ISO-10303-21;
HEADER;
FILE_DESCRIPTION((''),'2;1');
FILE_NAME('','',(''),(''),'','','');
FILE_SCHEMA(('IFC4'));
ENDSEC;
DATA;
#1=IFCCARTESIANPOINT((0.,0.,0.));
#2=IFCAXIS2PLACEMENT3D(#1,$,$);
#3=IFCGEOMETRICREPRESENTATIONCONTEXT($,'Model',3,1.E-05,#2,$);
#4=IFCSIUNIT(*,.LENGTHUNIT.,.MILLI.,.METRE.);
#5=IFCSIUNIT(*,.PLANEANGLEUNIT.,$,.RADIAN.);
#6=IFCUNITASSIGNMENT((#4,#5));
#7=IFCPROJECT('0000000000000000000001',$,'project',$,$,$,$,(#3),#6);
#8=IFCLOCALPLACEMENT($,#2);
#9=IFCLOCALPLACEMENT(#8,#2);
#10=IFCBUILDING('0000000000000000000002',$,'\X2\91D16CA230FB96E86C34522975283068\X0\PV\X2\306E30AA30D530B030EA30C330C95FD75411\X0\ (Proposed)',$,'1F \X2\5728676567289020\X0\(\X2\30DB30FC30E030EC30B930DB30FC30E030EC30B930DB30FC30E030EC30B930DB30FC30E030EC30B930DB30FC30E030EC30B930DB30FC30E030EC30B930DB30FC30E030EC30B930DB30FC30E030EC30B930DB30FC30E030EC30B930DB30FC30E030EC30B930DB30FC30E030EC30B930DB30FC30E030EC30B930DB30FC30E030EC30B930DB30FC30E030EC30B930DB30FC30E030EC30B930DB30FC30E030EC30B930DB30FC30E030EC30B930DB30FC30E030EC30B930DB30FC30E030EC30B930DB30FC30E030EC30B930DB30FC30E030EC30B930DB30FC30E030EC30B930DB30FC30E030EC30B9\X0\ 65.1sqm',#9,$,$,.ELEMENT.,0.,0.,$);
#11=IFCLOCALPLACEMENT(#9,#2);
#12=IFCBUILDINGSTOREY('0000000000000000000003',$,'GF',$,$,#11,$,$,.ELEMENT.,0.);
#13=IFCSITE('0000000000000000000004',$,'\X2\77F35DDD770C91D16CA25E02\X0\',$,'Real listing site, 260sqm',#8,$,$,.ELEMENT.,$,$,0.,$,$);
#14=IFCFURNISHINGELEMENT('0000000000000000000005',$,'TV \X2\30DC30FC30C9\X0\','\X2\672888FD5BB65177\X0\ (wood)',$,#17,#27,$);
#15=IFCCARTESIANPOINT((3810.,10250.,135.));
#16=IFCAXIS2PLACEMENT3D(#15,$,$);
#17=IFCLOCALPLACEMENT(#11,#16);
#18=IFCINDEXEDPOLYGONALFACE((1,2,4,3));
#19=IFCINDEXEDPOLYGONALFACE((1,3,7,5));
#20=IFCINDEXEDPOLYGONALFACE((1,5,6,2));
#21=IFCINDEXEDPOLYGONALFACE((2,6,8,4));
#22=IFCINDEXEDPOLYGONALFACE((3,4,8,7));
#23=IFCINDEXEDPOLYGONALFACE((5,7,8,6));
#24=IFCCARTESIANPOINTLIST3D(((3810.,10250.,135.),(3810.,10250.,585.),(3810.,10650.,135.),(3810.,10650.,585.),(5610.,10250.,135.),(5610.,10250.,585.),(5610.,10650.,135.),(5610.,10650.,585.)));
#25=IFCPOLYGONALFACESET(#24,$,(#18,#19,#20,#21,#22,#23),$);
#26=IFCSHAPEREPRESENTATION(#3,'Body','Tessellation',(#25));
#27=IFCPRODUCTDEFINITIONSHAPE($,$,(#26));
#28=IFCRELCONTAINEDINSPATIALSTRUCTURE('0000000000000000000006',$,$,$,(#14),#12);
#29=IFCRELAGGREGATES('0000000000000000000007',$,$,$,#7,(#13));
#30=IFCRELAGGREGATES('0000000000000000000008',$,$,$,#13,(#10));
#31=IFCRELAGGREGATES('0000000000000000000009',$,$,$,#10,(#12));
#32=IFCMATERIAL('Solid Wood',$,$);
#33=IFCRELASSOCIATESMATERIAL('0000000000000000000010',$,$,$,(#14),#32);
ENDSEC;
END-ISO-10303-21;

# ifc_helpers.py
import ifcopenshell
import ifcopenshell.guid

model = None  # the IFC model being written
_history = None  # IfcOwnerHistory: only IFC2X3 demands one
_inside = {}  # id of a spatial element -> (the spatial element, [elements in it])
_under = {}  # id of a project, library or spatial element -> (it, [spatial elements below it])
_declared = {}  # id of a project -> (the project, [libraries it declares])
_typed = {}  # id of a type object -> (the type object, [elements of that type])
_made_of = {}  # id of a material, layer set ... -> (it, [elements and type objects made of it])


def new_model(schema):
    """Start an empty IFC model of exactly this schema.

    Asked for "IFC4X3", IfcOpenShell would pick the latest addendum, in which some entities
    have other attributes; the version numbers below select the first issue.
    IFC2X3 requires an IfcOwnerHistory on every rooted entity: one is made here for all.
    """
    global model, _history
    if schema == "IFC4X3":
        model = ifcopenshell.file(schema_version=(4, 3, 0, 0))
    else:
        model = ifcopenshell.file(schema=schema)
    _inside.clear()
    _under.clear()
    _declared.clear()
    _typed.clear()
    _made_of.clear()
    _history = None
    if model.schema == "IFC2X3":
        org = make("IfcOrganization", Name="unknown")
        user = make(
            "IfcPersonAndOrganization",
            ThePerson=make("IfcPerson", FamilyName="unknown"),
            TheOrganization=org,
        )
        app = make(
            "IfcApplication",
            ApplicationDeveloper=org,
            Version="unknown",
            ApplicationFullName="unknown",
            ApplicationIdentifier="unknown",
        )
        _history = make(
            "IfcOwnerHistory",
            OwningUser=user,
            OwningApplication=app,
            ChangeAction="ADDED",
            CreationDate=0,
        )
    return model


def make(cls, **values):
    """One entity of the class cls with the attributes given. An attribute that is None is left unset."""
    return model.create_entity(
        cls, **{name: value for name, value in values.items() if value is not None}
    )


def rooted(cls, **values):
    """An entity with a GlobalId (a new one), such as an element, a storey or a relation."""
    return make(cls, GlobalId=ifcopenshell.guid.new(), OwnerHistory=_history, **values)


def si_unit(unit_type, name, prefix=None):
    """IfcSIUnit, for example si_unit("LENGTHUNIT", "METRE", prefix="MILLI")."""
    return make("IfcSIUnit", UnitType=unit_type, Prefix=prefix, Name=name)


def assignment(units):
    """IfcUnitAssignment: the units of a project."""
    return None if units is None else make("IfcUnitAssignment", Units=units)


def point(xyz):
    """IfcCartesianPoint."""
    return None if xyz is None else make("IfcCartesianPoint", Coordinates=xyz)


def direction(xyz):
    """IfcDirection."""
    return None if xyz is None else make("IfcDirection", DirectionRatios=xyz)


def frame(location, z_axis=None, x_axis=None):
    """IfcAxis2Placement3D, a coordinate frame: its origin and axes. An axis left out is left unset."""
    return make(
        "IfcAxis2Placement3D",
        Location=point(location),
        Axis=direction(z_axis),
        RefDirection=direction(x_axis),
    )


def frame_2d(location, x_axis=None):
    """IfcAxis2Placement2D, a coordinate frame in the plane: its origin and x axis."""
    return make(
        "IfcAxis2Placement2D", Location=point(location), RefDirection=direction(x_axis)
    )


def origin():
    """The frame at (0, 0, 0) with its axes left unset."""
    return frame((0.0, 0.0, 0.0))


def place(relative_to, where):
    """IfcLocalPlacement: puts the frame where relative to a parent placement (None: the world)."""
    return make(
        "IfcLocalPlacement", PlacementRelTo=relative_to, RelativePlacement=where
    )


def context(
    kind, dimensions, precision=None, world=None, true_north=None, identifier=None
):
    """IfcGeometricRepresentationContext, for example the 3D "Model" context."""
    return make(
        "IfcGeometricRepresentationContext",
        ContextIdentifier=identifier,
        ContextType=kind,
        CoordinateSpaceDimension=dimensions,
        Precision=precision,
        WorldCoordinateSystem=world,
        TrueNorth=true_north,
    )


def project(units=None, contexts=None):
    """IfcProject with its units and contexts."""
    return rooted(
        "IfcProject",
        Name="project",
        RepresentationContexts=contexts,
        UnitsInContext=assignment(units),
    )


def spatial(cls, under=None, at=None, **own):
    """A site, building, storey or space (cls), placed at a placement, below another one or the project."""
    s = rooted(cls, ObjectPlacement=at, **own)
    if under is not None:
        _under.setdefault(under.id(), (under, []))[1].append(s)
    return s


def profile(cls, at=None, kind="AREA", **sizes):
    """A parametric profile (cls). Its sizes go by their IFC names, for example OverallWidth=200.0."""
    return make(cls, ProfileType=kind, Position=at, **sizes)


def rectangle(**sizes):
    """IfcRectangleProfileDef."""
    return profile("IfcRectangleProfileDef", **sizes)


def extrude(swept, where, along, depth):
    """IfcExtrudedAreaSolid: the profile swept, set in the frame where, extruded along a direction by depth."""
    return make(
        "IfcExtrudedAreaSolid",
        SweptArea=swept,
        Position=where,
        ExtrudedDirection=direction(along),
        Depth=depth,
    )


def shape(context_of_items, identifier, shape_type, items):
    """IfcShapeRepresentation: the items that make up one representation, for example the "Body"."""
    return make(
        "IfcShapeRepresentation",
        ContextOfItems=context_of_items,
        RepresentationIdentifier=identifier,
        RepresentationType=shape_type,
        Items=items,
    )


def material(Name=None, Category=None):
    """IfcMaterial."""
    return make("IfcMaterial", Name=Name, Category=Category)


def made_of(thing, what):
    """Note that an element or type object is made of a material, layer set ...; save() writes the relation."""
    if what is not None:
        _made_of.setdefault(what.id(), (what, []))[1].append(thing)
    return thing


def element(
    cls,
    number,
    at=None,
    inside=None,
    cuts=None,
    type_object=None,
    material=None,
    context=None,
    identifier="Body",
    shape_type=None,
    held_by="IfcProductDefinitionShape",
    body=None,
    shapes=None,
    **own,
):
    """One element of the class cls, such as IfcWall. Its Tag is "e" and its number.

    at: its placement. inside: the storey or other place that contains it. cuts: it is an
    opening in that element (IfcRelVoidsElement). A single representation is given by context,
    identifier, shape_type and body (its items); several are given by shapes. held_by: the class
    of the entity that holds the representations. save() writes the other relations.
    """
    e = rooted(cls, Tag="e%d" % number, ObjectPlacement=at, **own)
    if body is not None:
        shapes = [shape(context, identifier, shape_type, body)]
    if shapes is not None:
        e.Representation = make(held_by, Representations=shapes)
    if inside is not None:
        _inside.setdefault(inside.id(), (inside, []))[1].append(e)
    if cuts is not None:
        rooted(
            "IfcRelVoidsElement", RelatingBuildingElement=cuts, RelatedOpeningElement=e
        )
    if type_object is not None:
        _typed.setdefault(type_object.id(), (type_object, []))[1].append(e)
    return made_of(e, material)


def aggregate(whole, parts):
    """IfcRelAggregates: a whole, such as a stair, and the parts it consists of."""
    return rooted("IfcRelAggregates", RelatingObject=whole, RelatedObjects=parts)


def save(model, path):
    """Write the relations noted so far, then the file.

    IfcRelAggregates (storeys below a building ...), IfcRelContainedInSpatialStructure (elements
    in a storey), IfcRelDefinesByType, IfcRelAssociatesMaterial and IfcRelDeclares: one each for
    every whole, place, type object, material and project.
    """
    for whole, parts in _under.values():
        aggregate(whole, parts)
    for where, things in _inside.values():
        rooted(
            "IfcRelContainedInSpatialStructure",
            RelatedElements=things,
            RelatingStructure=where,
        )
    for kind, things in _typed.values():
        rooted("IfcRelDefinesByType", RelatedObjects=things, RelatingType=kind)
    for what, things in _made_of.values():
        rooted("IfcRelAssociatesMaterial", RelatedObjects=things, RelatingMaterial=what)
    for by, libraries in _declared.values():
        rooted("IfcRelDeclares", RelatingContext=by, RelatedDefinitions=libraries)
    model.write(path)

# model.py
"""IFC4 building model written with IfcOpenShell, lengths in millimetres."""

from ifc_helpers import new_model, si_unit, frame, frame_2d, origin, place, context, project, spatial, rectangle, extrude, material, element, save


model = new_model("IFC4")

# Units and contexts
model_context = context("Model", 3, precision=1e-05, world=origin())
ifc_project = project(units=[si_unit("LENGTHUNIT", "METRE", prefix="MILLI"), si_unit("PLANEANGLEUNIT", "RADIAN")], contexts=[model_context])

# Site, building, storey
site_placement = place(None, origin())
site = spatial("IfcSite", under=ifc_project, at=site_placement, Name="石川県金沢市", ObjectType="Real listing site, 260sqm", CompositionType="ELEMENT", RefElevation=0.0)
building_placement = place(site_placement, origin())
building = spatial("IfcBuilding", under=site, at=building_placement, Name="金沢・雨水利用とPVのオフグリッド志向 (Proposed)", ObjectType="1F 在来木造(ホームレスホームレスホームレスホームレスホームレスホームレスホームレスホームレスホームレスホームレスホームレスホームレスホームレスホームレスホームレスホームレスホームレスホームレスホームレスホームレスホームレスホームレスホームレス 65.1sqm", CompositionType="ELEMENT", ElevationOfRefHeight=0.0, ElevationOfTerrain=0.0)
storey_placement = place(building_placement, origin())
storey = spatial("IfcBuildingStorey", under=building, at=storey_placement, Name="GF", CompositionType="ELEMENT", Elevation=0.0)

# Shared definitions
ifc_material_1 = material(Name="Solid Wood")

# Furnishing element
furnishing_placement = place(storey_placement, frame((3810.0, 10250.0, 135.0)))
element("IfcFurnishingElement", 1, at=furnishing_placement, inside=storey, material=ifc_material_1, Name="TV ボード", Description="木製家具 (wood)", context=model_context, shape_type="SweptSolid", body=[
    extrude(rectangle(XDim=1800.0, YDim=400.0, at=frame_2d((900.0, 200.0))), frame((3810.0, 10250.0, 135.0)), (0.0, 0.0, 1.0), 450.0),
])

save(model, "model.ifc")
